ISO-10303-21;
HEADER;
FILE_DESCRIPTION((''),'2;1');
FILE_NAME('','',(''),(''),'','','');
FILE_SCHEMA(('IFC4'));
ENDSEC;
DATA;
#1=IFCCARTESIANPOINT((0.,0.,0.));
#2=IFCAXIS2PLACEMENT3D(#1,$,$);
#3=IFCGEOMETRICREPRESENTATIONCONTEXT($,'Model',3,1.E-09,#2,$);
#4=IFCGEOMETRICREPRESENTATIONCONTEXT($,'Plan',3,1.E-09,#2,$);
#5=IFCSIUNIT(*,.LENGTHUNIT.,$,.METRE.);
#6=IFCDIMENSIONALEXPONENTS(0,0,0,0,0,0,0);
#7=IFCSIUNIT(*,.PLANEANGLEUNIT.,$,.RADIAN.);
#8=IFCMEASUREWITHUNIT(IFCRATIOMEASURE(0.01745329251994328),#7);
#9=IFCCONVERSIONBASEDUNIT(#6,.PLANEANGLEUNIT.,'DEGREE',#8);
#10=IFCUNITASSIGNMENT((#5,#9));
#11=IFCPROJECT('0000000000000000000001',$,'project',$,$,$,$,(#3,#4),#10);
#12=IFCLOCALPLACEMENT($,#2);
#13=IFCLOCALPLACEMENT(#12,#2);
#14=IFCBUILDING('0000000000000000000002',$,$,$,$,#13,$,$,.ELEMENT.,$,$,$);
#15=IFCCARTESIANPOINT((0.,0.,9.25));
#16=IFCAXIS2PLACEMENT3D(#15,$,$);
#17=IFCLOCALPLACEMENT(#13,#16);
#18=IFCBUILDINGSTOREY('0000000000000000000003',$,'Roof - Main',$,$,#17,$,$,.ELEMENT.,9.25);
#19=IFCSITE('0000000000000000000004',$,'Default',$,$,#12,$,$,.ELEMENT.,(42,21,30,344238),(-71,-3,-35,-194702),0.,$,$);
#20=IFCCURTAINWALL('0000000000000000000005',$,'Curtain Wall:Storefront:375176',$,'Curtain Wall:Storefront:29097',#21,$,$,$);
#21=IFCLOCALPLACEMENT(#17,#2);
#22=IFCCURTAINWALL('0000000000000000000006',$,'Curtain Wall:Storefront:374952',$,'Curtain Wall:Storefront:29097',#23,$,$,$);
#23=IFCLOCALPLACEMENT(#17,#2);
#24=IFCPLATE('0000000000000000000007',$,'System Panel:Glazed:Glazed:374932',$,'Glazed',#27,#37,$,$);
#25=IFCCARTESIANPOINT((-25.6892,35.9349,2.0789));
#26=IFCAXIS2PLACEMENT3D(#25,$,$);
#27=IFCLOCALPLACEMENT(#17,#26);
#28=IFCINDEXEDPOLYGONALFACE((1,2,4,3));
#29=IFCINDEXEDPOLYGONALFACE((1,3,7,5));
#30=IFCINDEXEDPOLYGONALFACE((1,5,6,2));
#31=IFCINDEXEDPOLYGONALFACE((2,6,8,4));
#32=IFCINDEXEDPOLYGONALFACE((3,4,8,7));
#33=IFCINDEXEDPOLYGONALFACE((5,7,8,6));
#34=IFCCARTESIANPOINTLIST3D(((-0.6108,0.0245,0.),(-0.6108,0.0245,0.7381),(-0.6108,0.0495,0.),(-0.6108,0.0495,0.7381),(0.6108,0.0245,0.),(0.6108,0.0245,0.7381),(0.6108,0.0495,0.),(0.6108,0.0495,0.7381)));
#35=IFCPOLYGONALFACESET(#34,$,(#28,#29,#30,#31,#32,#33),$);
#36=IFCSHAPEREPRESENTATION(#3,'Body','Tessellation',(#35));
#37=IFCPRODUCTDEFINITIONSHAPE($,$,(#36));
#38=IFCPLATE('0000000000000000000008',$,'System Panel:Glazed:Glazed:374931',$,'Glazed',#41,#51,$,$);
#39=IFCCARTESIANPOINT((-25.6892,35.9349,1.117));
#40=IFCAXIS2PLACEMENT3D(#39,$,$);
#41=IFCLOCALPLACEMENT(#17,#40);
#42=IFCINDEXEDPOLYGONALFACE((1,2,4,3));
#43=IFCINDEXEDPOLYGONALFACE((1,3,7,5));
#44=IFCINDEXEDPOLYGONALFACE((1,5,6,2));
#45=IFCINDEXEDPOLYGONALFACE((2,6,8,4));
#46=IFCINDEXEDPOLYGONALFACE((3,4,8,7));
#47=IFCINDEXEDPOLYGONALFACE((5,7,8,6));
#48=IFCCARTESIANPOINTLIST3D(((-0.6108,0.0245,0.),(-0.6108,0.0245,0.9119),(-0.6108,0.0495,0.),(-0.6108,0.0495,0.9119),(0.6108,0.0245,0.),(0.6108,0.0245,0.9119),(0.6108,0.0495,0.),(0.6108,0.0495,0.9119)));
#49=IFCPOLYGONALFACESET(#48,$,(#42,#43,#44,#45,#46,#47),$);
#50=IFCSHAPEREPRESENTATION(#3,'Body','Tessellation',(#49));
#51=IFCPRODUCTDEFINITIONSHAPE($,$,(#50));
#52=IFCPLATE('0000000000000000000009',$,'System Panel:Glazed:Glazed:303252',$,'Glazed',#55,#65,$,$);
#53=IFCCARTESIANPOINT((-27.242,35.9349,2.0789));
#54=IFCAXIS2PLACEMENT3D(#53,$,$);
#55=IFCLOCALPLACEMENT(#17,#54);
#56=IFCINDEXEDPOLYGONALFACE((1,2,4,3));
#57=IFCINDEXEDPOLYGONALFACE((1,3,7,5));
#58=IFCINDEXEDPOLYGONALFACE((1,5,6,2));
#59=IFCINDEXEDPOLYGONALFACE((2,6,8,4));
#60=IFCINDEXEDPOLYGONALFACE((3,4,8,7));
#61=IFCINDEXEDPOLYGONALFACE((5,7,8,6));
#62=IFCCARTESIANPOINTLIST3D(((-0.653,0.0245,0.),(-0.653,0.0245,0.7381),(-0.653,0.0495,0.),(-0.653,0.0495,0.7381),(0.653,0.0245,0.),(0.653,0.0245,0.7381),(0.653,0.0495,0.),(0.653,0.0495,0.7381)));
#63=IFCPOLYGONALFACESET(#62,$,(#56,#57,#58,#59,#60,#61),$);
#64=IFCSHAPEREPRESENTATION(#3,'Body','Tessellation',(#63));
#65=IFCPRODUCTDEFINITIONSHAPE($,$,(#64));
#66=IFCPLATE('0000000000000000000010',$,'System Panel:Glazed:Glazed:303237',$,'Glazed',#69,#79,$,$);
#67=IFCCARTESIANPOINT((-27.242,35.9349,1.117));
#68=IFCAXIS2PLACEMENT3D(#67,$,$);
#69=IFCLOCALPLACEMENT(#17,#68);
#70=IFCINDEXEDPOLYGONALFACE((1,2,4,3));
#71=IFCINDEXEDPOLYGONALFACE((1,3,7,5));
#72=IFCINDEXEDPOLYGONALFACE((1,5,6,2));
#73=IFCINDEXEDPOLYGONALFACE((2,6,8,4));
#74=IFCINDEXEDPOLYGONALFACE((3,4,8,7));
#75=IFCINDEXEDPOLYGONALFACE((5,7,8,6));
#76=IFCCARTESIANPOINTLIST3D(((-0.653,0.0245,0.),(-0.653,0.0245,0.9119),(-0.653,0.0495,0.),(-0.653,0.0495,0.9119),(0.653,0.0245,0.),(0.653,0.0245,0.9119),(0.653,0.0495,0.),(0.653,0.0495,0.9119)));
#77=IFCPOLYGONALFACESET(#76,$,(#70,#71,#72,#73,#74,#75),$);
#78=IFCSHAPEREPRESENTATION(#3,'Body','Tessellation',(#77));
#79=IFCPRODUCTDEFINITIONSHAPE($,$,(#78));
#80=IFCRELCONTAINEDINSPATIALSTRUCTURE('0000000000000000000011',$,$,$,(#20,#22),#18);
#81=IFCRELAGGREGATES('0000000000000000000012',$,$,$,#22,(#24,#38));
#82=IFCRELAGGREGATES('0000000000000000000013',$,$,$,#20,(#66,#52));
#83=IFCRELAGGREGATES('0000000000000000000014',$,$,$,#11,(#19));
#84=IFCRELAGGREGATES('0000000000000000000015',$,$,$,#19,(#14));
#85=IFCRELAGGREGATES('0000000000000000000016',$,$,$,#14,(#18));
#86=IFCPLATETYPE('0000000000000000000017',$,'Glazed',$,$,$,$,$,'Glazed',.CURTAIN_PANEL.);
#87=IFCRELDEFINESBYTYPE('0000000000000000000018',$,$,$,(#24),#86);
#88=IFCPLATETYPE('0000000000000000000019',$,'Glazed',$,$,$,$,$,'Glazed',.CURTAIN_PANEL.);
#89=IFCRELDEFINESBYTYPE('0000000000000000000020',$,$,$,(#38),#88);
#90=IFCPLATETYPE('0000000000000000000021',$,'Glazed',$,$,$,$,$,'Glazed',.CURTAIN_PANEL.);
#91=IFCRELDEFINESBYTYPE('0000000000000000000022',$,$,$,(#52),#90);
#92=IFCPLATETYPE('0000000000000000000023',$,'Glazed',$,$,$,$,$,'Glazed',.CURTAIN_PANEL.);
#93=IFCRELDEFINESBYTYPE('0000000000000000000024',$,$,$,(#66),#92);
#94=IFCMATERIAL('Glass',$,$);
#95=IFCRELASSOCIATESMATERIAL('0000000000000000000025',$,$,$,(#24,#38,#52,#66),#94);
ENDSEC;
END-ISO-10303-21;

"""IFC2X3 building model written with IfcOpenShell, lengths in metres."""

from ifc_helpers import new_model, entity, si_unit, converted_unit, frame, origin, origin_2d_with_axis, place, context, project, spatial, rectangle, extrude, source, transform, mapped, material, type_object, type_shapes, element, aggregate, save


model = new_model("IFC2X3")

# Units and contexts
model_context = context("Model", 3, precision=1e-09, world=origin())
plan_context = context("Plan", 3, precision=1e-09, world=origin())
ifc_project = project(units=[si_unit("LENGTHUNIT", "METRE"), converted_unit("PLANEANGLEUNIT", "DEGREE", entity("IfcRatioMeasure", 0.01745329251994328), si_unit("PLANEANGLEUNIT", "RADIAN"), dimensions=[0, 0, 0, 0, 0, 0, 0])], contexts=[model_context, plan_context])

# Site, building, storey
site_placement = place(None, origin())
site = spatial("IfcSite", under=ifc_project, at=site_placement, Name="Default", CompositionType="ELEMENT", RefLatitude=(42, 21, 30, 344238), RefLongitude=(-71, -3, -35, -194702), RefElevation=0.0)
building_placement = place(site_placement, origin())
building = spatial("IfcBuilding", under=site, at=building_placement, CompositionType="ELEMENT")
storey_placement = place(building_placement, frame((0.0, 0.0, 9.25)))
storey = spatial("IfcBuildingStorey", under=building, at=storey_placement, Name="Roof - Main", CompositionType="ELEMENT", Elevation=9.25)

# Curtain walls
curtain_wall_1_placement = place(storey_placement, origin())
curtain_wall_1 = element("IfcCurtainWall", 1, at=curtain_wall_1_placement, inside=storey, Name="Curtain Wall:Storefront:375176", ObjectType="Curtain Wall:Storefront:29097")
curtain_wall_2_placement = place(storey_placement, origin())
curtain_wall_2 = element("IfcCurtainWall", 2, at=curtain_wall_2_placement, inside=storey, Name="Curtain Wall:Storefront:374952", ObjectType="Curtain Wall:Storefront:29097")

# Plates
ifc_material_1 = material(Name="Glass")
plate_type_1 = type_object("IfcPlateType", Name="Glazed", ElementType="Glazed", PredefinedType="CURTAIN_PANEL")
shared_shape_1 = source(origin(), model_context, "Body", "SweptSolid", [
    extrude(rectangle(XDim=0.025, YDim=1.2217, at=origin_2d_with_axis()), frame((0.0, 0.037, 0.0), z_axis=(0.0, 0.0, 1.0), x_axis=(0.0, 1.0, 0.0)), (0.0, 0.0, 1.0), 0.7381),
])
type_shapes(plate_type_1, [shared_shape_1])
plate_1_placement = place(storey_placement, frame((-25.6892, 35.9349, 2.0789)))
plate_1 = element("IfcPlate", 3, at=plate_1_placement, type_object=plate_type_1, material=ifc_material_1, Name="System Panel:Glazed:Glazed:374932", ObjectType="Glazed", context=model_context, shape_type="MappedRepresentation", body=[
    mapped(shared_shape_1, transform((0.0, 0.0, 0.0), scale=1.0)),
])
plate_type_2 = type_object("IfcPlateType", Name="Glazed", ElementType="Glazed", PredefinedType="CURTAIN_PANEL")
shared_shape_2 = source(origin(), model_context, "Body", "SweptSolid", [
    extrude(rectangle(XDim=0.025, YDim=1.2217, at=origin_2d_with_axis()), frame((0.0, 0.037, 0.0), z_axis=(0.0, 0.0, 1.0), x_axis=(0.0, 1.0, 0.0)), (0.0, 0.0, 1.0), 0.9119),
])
type_shapes(plate_type_2, [shared_shape_2])
plate_2_placement = place(storey_placement, frame((-25.6892, 35.9349, 1.117)))
plate_2 = element("IfcPlate", 4, at=plate_2_placement, type_object=plate_type_2, material=ifc_material_1, Name="System Panel:Glazed:Glazed:374931", ObjectType="Glazed", context=model_context, shape_type="MappedRepresentation", body=[
    mapped(shared_shape_2, transform((0.0, 0.0, 0.0), scale=1.0)),
])
aggregate(curtain_wall_2, [plate_1, plate_2])
plate_type_3 = type_object("IfcPlateType", Name="Glazed", ElementType="Glazed", PredefinedType="CURTAIN_PANEL")
shared_shape_3 = source(origin(), model_context, "Body", "SweptSolid", [
    extrude(rectangle(XDim=0.025, YDim=1.306, at=origin_2d_with_axis()), frame((0.0, 0.037, 0.0), z_axis=(0.0, 0.0, 1.0), x_axis=(0.0, 1.0, 0.0)), (0.0, 0.0, 1.0), 0.7381),
])
type_shapes(plate_type_3, [shared_shape_3])
plate_3_placement = place(storey_placement, frame((-27.242, 35.9349, 2.0789)))
plate_3 = element("IfcPlate", 5, at=plate_3_placement, type_object=plate_type_3, material=ifc_material_1, Name="System Panel:Glazed:Glazed:303252", ObjectType="Glazed", context=model_context, shape_type="MappedRepresentation", body=[
    mapped(shared_shape_3, transform((0.0, 0.0, 0.0), scale=1.0)),
])
plate_type_4 = type_object("IfcPlateType", Name="Glazed", ElementType="Glazed", PredefinedType="CURTAIN_PANEL")
shared_shape_4 = source(origin(), model_context, "Body", "SweptSolid", [
    extrude(rectangle(XDim=0.025, YDim=1.306, at=origin_2d_with_axis()), frame((0.0, 0.037, 0.0), z_axis=(0.0, 0.0, 1.0), x_axis=(0.0, 1.0, 0.0)), (0.0, 0.0, 1.0), 0.9119),
])
type_shapes(plate_type_4, [shared_shape_4])
plate_4_placement = place(storey_placement, frame((-27.242, 35.9349, 1.117)))
plate_4 = element("IfcPlate", 6, at=plate_4_placement, type_object=plate_type_4, material=ifc_material_1, Name="System Panel:Glazed:Glazed:303237", ObjectType="Glazed", context=model_context, shape_type="MappedRepresentation", body=[
    mapped(shared_shape_4, transform((0.0, 0.0, 0.0), scale=1.0)),
])
aggregate(curtain_wall_1, [plate_4, plate_3])

save(model, "model.ifc")
